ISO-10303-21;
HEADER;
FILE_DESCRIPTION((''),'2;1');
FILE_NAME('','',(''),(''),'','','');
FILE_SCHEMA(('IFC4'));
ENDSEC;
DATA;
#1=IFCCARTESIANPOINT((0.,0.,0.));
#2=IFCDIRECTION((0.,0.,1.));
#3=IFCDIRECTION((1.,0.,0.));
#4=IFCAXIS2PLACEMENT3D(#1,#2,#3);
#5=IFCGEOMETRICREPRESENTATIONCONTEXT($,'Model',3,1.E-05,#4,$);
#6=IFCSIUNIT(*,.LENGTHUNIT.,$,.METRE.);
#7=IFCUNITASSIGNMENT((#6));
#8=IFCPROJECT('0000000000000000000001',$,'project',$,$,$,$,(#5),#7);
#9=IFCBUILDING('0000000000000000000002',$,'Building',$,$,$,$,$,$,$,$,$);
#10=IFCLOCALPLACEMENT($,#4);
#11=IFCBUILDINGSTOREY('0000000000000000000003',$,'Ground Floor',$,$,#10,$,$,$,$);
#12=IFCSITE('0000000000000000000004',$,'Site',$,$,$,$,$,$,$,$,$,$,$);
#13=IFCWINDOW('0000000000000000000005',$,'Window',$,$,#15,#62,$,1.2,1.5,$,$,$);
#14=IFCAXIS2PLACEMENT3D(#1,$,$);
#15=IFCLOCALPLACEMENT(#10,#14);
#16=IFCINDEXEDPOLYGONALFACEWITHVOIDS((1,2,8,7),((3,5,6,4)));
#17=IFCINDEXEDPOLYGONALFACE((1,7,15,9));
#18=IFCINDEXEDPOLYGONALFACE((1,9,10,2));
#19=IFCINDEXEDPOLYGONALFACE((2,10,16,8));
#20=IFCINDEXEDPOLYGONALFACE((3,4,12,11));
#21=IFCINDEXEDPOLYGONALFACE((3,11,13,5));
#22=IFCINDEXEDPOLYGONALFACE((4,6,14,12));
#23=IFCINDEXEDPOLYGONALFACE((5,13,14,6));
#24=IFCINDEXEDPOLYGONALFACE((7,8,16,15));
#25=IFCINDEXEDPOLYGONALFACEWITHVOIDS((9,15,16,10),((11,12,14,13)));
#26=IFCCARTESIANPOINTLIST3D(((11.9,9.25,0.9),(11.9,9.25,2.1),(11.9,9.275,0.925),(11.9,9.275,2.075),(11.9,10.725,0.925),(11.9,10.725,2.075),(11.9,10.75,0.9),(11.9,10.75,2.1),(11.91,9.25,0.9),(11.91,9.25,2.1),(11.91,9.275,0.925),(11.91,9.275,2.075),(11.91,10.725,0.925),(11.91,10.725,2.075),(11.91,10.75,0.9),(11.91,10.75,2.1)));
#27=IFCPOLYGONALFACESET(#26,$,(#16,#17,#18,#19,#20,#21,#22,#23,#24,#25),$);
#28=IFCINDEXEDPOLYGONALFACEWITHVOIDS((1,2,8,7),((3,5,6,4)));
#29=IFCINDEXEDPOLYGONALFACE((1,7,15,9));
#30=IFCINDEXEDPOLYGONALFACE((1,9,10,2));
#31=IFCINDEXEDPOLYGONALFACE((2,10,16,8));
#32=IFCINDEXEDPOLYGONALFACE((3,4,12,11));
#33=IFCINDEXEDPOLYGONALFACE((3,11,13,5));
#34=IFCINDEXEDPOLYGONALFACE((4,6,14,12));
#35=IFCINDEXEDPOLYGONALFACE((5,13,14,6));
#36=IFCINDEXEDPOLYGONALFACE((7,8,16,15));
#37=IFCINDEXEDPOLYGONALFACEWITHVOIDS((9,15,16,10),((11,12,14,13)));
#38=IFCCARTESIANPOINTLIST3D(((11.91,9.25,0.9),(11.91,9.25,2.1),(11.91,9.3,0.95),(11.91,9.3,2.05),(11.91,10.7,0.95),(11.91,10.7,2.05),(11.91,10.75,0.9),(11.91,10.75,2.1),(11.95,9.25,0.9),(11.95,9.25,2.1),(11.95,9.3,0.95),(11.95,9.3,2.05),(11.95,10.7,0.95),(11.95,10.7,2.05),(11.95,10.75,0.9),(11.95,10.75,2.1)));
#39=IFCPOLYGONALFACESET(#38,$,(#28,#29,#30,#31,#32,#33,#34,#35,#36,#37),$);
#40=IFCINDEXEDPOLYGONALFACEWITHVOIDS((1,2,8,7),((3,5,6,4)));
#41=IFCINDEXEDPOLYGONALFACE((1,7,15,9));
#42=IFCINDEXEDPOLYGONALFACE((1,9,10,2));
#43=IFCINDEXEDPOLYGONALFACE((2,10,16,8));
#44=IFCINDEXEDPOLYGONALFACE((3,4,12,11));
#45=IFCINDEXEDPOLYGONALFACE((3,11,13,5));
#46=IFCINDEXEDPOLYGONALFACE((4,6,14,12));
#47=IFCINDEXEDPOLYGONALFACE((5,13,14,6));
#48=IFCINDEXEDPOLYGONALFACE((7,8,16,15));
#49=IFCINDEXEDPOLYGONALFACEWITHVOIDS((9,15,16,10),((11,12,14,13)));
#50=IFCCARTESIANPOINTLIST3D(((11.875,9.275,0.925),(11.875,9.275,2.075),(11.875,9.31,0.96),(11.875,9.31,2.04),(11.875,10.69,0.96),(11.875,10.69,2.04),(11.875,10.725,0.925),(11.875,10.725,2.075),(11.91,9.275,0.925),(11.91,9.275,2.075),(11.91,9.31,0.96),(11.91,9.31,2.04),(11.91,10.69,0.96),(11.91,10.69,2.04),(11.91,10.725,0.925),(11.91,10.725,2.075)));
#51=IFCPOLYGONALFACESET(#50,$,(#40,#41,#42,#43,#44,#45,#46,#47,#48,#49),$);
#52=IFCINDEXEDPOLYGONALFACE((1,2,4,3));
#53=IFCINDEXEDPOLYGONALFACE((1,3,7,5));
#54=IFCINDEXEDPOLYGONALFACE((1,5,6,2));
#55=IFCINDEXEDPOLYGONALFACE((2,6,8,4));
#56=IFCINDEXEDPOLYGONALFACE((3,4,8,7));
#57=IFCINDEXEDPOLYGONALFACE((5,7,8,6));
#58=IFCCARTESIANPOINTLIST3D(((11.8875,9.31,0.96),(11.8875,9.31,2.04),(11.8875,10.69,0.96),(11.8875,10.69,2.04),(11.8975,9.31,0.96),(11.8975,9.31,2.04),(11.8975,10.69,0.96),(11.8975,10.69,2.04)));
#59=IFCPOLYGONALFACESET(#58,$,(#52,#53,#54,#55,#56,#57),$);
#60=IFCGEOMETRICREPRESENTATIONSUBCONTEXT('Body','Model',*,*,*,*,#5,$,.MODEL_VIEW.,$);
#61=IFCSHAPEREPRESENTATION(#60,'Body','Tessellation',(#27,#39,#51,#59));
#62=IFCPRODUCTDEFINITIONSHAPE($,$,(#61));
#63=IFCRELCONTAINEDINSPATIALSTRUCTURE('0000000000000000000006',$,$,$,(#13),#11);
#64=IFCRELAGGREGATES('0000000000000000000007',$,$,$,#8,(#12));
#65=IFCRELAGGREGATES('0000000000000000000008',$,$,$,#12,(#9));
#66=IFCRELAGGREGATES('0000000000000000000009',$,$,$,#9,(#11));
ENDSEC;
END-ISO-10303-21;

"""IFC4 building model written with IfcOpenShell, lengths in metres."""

from ifc_helpers import new_model, si_unit, frame, origin_with_axes, place, context, subcontext, project, spatial, line, indexed_curve, outline, extrude, element, save


model = new_model("IFC4")

# Units and contexts
model_context = context("Model", 3, precision=1e-05, world=origin_with_axes())
body_context = subcontext(model_context, "Body", "Model", "MODEL_VIEW")
ifc_project = project(units=[si_unit("LENGTHUNIT", "METRE")], contexts=[model_context])

# Site, building, storey
site = spatial("IfcSite", under=ifc_project, Name="Site")
building = spatial("IfcBuilding", under=site, Name="Building")
storey_placement = place(None, origin_with_axes())
storey = spatial("IfcBuildingStorey", under=building, at=storey_placement, Name="Ground Floor")

# Window
window_1_placement = place(storey_placement, frame((12.0, 9.25, 0.9), z_axis=(0.0, 0.0, 1.0), x_axis=(0.0, 1.0, 0.0)))
element("IfcWindow", 1, at=window_1_placement, inside=storey, Name="Window", OverallHeight=1.2, OverallWidth=1.5, context=body_context, shape_type="SweptSolid", body=[
    extrude(outline(indexed_curve([(0.0, 0.0), (1.5, 0.0), (1.5, 1.2), (0.0, 1.2)], segments=[line(1, 2, 3, 4, 1)]), holes=[indexed_curve([(0.025, 0.025), (1.475, 0.025), (1.475, 1.175), (0.025, 1.175)], segments=[line(1, 2, 3, 4, 1)])]), frame((0.0, 0.09, 0.0), z_axis=(0.0, -1.0, 0.0), x_axis=(1.0, 0.0, 0.0)), (0.0, 0.0, -1.0), 0.01),
    extrude(outline(indexed_curve([(0.0, 0.0), (1.5, 0.0), (1.5, 1.2), (0.0, 1.2)], segments=[line(1, 2, 3, 4, 1)]), holes=[indexed_curve([(0.05, 0.05), (1.45, 0.05), (1.45, 1.15), (0.05, 1.15)], segments=[line(1, 2, 3, 4, 1)])]), frame((0.0, 0.05, 0.0), z_axis=(0.0, -1.0, 0.0), x_axis=(1.0, 0.0, 0.0)), (0.0, 0.0, -1.0), 0.04),
    extrude(outline(indexed_curve([(0.0, 0.0), (1.45, 0.0), (1.45, 1.15), (0.0, 1.15)], segments=[line(1, 2, 3, 4, 1)]), holes=[indexed_curve([(0.035, 0.035), (1.415, 0.035), (1.415, 1.115), (0.035, 1.115)], segments=[line(1, 2, 3, 4, 1)])]), frame((0.025, 0.09, 0.025), z_axis=(0.0, -1.0, 0.0), x_axis=(1.0, 0.0, 0.0)), (0.0, 0.0, -1.0), 0.035),
    extrude(outline(indexed_curve([(0.035, 0.035), (1.415, 0.035), (1.415, 1.115), (0.035, 1.115)], segments=[line(1, 2, 3, 4, 1)])), frame((0.025, 0.1025, 0.025), z_axis=(0.0, -1.0, 0.0), x_axis=(1.0, 0.0, 0.0)), (0.0, 0.0, -1.0), 0.01),
])

save(model, "model.ifc")
